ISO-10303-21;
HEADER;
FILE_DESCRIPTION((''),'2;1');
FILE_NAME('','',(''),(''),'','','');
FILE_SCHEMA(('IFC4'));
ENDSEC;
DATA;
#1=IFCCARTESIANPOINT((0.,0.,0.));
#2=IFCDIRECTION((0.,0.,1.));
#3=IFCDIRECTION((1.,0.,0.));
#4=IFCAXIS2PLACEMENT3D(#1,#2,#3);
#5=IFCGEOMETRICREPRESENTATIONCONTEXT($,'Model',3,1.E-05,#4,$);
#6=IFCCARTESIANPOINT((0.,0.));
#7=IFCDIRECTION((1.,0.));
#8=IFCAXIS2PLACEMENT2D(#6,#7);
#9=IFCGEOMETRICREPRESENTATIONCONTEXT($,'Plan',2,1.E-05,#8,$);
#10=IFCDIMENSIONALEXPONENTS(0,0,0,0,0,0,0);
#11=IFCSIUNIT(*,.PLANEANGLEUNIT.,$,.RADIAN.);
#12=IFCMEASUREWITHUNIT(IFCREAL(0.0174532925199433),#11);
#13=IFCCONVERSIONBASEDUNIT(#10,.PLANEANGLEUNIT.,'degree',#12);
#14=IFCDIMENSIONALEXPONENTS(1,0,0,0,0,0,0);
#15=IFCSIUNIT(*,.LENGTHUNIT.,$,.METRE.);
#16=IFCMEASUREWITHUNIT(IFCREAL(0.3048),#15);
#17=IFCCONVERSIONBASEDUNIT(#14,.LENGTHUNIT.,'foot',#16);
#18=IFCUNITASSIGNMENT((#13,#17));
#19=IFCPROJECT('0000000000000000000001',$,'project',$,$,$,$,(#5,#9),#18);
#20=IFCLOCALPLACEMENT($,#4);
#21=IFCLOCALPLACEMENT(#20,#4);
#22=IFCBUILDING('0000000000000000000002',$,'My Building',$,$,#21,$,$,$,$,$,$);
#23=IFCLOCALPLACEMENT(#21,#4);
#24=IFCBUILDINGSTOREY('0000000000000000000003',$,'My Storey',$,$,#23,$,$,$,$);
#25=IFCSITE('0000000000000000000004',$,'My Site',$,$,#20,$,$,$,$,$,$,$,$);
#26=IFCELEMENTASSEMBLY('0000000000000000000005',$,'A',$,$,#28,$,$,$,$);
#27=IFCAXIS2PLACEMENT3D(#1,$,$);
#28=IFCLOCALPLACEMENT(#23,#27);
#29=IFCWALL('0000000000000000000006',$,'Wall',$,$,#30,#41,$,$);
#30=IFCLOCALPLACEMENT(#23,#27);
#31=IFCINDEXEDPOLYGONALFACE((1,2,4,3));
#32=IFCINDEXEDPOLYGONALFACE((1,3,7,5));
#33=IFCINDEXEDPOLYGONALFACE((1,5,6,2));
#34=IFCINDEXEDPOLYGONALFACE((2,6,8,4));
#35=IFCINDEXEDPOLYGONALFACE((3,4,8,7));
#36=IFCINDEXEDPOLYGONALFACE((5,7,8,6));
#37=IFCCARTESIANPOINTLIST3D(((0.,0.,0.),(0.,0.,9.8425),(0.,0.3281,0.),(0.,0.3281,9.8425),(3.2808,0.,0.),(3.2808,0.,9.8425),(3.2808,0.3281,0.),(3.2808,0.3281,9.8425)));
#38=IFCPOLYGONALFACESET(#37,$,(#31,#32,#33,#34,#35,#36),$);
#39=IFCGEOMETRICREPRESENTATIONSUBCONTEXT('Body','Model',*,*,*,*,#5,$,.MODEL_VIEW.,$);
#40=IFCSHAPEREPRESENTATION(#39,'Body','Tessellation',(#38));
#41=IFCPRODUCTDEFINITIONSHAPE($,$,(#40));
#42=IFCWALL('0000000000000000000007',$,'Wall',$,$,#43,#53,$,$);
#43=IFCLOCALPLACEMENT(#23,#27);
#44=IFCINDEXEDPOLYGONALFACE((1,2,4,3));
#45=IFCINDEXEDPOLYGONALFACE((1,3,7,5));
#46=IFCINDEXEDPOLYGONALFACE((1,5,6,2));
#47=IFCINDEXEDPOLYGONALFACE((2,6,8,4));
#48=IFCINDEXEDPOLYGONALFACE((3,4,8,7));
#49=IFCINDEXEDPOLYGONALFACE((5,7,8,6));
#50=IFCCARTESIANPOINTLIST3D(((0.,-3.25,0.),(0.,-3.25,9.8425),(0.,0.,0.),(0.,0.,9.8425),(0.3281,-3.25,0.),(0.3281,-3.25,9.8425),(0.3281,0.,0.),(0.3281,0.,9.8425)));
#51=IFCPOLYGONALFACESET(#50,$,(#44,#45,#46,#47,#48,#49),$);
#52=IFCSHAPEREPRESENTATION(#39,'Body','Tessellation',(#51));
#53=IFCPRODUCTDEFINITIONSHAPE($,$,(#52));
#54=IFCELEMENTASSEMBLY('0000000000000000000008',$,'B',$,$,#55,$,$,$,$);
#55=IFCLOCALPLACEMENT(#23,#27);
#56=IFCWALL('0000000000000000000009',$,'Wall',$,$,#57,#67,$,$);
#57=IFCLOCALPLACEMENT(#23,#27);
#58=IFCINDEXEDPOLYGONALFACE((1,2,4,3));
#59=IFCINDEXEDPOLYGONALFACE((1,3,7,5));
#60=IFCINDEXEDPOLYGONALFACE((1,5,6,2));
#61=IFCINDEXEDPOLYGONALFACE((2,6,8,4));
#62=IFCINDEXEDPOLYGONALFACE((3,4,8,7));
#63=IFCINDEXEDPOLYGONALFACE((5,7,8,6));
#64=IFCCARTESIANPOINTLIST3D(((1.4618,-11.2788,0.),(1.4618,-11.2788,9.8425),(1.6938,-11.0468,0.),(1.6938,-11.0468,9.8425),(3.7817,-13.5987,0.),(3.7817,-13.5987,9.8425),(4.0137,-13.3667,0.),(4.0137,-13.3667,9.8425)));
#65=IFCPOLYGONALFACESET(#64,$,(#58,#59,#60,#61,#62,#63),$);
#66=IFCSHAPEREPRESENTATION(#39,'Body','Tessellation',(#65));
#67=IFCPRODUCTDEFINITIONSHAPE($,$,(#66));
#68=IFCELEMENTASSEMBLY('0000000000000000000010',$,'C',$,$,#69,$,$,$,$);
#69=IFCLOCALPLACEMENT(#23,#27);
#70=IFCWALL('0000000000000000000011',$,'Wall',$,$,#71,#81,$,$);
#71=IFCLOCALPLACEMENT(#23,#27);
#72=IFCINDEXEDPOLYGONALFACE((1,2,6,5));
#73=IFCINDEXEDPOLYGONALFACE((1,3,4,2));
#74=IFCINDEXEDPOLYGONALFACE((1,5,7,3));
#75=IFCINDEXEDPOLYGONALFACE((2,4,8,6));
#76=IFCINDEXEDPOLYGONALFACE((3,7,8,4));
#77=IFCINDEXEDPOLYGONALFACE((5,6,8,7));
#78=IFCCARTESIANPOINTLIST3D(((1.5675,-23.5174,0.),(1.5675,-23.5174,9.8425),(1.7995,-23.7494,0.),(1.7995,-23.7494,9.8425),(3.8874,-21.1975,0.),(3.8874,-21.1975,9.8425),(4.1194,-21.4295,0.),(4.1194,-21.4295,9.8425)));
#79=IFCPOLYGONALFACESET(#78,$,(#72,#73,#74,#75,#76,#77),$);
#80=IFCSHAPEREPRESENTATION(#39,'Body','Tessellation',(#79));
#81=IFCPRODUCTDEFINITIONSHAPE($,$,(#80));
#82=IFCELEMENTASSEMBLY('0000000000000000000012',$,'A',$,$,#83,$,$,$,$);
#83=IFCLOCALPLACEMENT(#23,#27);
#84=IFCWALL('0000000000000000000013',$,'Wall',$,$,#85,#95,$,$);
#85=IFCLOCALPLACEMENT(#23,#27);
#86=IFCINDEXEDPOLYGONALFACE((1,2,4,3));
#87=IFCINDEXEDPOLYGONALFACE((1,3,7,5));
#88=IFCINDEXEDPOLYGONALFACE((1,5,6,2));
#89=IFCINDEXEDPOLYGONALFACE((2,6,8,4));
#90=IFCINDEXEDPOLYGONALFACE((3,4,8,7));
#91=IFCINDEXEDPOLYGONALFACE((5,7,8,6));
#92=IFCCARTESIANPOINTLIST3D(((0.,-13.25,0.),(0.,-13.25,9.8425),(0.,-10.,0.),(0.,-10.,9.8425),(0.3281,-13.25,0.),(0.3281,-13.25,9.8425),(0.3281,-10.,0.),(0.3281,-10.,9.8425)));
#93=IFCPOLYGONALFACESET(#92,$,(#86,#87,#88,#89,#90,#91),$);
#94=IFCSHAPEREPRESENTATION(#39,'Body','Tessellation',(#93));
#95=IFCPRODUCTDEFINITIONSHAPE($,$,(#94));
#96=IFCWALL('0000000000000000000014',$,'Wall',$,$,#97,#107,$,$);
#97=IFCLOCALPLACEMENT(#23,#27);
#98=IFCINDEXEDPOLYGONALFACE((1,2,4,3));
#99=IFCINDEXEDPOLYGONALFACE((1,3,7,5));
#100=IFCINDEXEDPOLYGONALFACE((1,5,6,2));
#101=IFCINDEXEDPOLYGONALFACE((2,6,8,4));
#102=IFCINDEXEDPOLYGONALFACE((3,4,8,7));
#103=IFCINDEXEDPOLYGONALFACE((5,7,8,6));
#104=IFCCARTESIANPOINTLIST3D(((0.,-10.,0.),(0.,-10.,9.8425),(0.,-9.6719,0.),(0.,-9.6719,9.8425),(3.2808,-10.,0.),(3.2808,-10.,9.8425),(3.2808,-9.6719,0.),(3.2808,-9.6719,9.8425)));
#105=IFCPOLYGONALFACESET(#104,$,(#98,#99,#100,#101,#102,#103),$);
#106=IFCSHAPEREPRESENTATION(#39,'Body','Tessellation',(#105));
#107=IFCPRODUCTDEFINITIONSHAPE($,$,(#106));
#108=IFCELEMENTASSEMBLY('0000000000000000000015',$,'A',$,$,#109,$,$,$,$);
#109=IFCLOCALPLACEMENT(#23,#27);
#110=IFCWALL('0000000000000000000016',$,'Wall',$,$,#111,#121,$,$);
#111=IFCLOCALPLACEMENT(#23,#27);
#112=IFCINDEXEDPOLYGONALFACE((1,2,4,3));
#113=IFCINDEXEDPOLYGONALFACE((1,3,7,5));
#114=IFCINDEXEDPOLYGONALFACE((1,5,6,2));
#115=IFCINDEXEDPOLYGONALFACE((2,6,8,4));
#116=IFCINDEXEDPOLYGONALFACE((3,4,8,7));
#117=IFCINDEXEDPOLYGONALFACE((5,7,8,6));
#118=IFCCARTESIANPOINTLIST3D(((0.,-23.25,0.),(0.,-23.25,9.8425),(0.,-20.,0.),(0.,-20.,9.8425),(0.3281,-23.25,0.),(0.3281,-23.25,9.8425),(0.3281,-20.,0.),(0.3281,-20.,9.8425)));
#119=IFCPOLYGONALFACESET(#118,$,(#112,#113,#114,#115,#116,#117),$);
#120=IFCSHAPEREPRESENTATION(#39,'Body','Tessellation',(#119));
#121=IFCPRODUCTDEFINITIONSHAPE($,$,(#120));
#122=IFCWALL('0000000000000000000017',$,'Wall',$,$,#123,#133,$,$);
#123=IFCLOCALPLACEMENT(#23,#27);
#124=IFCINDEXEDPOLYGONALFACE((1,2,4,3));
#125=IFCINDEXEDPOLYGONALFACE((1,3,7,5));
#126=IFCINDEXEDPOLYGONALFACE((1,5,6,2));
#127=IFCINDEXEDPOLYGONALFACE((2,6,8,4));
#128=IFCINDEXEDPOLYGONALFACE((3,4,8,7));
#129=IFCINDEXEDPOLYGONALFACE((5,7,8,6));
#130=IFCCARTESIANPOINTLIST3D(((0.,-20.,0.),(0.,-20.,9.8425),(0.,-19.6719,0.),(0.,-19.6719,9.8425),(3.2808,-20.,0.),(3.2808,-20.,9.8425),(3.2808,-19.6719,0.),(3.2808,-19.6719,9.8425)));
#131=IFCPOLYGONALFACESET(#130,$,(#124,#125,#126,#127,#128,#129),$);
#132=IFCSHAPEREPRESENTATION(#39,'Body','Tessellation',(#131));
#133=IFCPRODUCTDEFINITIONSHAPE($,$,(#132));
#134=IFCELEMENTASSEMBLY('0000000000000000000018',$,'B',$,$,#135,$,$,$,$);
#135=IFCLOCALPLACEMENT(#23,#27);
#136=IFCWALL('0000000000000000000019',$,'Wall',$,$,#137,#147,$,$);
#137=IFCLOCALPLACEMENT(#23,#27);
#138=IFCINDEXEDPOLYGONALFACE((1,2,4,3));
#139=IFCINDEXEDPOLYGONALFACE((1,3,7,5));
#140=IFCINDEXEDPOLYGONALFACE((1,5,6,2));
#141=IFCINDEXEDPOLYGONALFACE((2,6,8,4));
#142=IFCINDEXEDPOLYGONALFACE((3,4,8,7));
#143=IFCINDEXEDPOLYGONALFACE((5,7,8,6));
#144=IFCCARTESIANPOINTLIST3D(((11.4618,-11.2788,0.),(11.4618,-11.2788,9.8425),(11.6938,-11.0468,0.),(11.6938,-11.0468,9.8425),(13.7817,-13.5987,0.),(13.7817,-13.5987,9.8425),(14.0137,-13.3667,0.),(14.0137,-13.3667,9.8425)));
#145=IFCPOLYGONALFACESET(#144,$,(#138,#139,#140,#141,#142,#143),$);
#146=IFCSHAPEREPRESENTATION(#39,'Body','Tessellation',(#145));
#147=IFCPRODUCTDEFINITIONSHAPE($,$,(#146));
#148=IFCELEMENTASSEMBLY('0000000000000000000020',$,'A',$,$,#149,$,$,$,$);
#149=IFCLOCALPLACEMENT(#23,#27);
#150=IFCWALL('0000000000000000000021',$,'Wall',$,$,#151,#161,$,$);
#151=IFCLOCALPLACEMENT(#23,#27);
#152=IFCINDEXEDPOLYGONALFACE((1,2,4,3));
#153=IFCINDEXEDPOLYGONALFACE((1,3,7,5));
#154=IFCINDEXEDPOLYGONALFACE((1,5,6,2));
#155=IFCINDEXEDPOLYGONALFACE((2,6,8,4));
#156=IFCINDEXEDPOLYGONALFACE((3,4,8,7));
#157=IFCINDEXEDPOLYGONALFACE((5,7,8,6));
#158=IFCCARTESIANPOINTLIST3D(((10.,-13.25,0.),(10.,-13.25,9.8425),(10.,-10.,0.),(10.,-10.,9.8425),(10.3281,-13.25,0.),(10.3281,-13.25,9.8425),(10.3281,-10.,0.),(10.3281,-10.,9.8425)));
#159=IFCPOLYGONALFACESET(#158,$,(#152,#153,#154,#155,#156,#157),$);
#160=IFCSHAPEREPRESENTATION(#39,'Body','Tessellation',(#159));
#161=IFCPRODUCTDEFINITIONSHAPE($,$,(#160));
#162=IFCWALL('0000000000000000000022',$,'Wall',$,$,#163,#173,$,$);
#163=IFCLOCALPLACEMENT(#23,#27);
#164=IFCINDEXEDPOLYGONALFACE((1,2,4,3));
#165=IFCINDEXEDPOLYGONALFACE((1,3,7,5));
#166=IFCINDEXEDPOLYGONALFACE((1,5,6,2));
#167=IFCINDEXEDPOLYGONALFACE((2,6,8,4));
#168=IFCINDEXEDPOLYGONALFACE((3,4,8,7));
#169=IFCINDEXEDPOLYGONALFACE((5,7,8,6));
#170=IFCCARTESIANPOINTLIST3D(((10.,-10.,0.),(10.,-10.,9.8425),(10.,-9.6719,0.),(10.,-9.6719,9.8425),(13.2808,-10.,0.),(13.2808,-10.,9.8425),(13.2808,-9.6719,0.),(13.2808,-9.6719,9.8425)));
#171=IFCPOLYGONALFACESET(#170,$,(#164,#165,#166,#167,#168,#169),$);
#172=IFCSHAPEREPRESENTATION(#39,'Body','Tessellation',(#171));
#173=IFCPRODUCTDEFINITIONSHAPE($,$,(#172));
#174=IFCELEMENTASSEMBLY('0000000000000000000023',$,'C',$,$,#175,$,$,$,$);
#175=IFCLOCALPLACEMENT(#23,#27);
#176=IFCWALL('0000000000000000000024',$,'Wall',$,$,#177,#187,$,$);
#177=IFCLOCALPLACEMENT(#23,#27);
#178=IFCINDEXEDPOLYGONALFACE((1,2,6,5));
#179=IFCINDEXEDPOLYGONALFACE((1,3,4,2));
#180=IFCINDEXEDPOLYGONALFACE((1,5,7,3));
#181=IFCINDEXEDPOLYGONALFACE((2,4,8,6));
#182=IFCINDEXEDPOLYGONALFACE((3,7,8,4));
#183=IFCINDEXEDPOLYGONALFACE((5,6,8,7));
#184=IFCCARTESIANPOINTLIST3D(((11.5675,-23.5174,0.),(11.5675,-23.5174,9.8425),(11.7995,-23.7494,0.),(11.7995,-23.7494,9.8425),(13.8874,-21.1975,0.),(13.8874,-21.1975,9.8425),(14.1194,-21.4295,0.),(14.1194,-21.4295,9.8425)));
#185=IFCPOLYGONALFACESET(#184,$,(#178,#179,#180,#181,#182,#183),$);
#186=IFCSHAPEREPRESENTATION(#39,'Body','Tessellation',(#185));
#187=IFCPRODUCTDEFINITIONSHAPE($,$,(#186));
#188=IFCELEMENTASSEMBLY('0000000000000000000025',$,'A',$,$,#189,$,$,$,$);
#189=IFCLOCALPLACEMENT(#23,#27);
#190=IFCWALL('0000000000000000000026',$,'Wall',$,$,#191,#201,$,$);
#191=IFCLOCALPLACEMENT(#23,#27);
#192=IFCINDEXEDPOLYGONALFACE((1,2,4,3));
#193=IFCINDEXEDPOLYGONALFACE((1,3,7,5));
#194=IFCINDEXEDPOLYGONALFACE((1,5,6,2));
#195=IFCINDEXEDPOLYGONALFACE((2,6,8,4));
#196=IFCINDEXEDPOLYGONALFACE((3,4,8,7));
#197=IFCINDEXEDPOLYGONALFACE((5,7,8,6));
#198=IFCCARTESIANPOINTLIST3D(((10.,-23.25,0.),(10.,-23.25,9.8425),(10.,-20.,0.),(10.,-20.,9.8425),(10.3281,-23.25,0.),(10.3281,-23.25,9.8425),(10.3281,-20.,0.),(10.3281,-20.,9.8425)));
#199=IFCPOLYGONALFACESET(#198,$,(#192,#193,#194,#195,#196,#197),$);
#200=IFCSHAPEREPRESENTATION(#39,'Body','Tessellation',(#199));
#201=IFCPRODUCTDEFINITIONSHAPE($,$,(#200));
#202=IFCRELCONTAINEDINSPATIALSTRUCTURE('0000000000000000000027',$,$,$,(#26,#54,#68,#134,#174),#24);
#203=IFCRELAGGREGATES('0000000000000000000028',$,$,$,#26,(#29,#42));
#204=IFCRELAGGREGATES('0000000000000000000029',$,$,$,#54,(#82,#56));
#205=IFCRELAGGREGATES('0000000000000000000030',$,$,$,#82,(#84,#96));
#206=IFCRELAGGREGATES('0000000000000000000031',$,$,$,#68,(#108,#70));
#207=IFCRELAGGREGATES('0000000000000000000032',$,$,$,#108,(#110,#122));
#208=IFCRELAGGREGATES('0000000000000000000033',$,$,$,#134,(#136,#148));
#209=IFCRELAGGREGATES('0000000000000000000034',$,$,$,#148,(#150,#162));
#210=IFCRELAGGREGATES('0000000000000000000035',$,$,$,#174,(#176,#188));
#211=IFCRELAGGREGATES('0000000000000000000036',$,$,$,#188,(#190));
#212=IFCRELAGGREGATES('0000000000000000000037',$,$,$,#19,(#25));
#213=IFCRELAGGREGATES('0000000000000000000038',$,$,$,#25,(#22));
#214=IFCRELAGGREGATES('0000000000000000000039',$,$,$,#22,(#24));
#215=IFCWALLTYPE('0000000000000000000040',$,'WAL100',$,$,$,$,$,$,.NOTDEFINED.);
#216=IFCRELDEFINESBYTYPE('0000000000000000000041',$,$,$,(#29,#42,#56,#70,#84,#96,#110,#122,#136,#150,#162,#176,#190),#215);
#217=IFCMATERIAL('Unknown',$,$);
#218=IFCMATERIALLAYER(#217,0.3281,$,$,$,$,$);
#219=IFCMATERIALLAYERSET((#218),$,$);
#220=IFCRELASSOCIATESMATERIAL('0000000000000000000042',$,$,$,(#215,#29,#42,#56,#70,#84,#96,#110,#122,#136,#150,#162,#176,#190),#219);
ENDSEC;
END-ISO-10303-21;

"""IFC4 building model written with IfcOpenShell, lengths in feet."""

from ifc_helpers import new_model, entity, si_unit, converted_unit, frame, origin_with_axes, origin_2d_with_axis, place, context, subcontext, project, spatial, indexed_curve, outline, extrude, material, layer, layer_set, layer_usage, type_object, element, aggregate, save


model = new_model("IFC4")

# Units and contexts
model_context = context("Model", 3, precision=1e-05, world=origin_with_axes())
plan_context = context("Plan", 2, precision=1e-05, world=origin_2d_with_axis())
body_context = subcontext(model_context, "Body", "Model", "MODEL_VIEW")
ifc_project = project(units=[converted_unit("PLANEANGLEUNIT", "degree", entity("IfcReal", 0.0174532925199433), si_unit("PLANEANGLEUNIT", "RADIAN"), dimensions=[0, 0, 0, 0, 0, 0, 0]), converted_unit("LENGTHUNIT", "foot", entity("IfcReal", 0.3048), si_unit("LENGTHUNIT", "METRE"), dimensions=[1, 0, 0, 0, 0, 0, 0])], contexts=[model_context, plan_context])

# Site, building, storey
site_placement = place(None, origin_with_axes())
site = spatial("IfcSite", under=ifc_project, at=site_placement, Name="My Site")
building_placement = place(site_placement, origin_with_axes())
building = spatial("IfcBuilding", under=site, at=building_placement, Name="My Building")
storey_placement = place(building_placement, origin_with_axes())
storey = spatial("IfcBuildingStorey", under=building, at=storey_placement, Name="My Storey")

# Element assembly, walls
assembly_1_placement = place(storey_placement, origin_with_axes())
assembly_1 = element("IfcElementAssembly", 1, at=assembly_1_placement, inside=storey, Name="A")
ifc_material = material(Name="Unknown")
ifc_layer = layer(ifc_material, 0.3281)
ifc_layer_set = layer_set([ifc_layer])
ifc_layer_usage_1 = layer_usage(ifc_layer_set, "AXIS2", "POSITIVE", 0.0)
wall_type = type_object("IfcWallType", Name="WAL100", PredefinedType="NOTDEFINED", material=ifc_layer_set)
wall_1_placement = place(assembly_1_placement, origin_with_axes())
wall_1 = element("IfcWall", 2, at=wall_1_placement, type_object=wall_type, material=ifc_layer_usage_1, Name="Wall", context=body_context, shape_type="SweptSolid", body=[
    extrude(outline(indexed_curve([(0.0, 0.0), (0.0, 0.3281), (3.2808, 0.3281), (3.2808, 0.0), (0.0, 0.0)], self_intersect=False)), origin_with_axes(), (0.0, 0.0, 1.0), 9.8425),
])
ifc_layer_usage_2 = layer_usage(ifc_layer_set, "AXIS2", "POSITIVE", 0.0)
wall_2_placement = place(assembly_1_placement, frame((0.0, 0.0, 0.0), z_axis=(0.0, 0.0, 1.0), x_axis=(0.0, -1.0, 0.0)))
wall_2 = element("IfcWall", 3, at=wall_2_placement, type_object=wall_type, material=ifc_layer_usage_2, Name="Wall", context=body_context, shape_type="SweptSolid", body=[
    extrude(outline(indexed_curve([(0.0, 0.0), (0.0, 0.3281), (3.25, 0.3281), (3.25, 0.0), (0.0, 0.0)], self_intersect=False)), origin_with_axes(), (0.0, 0.0, 1.0), 9.8425),
])
aggregate(assembly_1, [wall_1, wall_2])

# Element assemblies, walls
assembly_2_placement = place(storey_placement, origin_with_axes())
assembly_2 = element("IfcElementAssembly", 4, at=assembly_2_placement, inside=storey, Name="B")
ifc_layer_usage_3 = layer_usage(ifc_layer_set, "AXIS2", "POSITIVE", 0.0)
wall_3_placement = place(assembly_2_placement, frame((1.4618, -11.2788, 0.0), z_axis=(0.0, 0.0, 1.0), x_axis=(0.707107, -0.707107, 0.0)))
wall_3 = element("IfcWall", 5, at=wall_3_placement, type_object=wall_type, material=ifc_layer_usage_3, Name="Wall", context=body_context, shape_type="SweptSolid", body=[
    extrude(outline(indexed_curve([(0.0, 0.0), (0.0, 0.3281), (3.2808, 0.3281), (3.2808, 0.0), (0.0, 0.0)], self_intersect=False)), origin_with_axes(), (0.0, 0.0, 1.0), 9.8425),
])
assembly_3_placement = place(storey_placement, origin_with_axes())
assembly_3 = element("IfcElementAssembly", 6, at=assembly_3_placement, inside=storey, Name="C")
ifc_layer_usage_4 = layer_usage(ifc_layer_set, "AXIS2", "POSITIVE", 0.0)
wall_4_placement = place(assembly_3_placement, frame((1.7995, -23.7494, 0.0), z_axis=(0.0, 0.0, 1.0), x_axis=(0.707107, 0.707107, 0.0)))
wall_4 = element("IfcWall", 7, at=wall_4_placement, type_object=wall_type, material=ifc_layer_usage_4, Name="Wall", context=body_context, shape_type="SweptSolid", body=[
    extrude(outline(indexed_curve([(0.0, 0.0), (0.0, 0.3281), (3.2808, 0.3281), (3.2808, 0.0), (0.0, 0.0)], self_intersect=False)), origin_with_axes(), (0.0, 0.0, 1.0), 9.8425),
])

# Element assembly
assembly_4_placement = place(assembly_2_placement, frame((0.0, -10.0, 0.0), z_axis=(0.0, 0.0, 1.0), x_axis=(1.0, 0.0, 0.0)))
assembly_4 = element("IfcElementAssembly", 8, at=assembly_4_placement, Name="A")
aggregate(assembly_2, [assembly_4, wall_3])

# Walls
ifc_layer_usage_5 = layer_usage(ifc_layer_set, "AXIS2", "POSITIVE", 0.0)
wall_5_placement = place(assembly_4_placement, frame((0.0, 0.0, 0.0), z_axis=(0.0, 0.0, 1.0), x_axis=(0.0, -1.0, 0.0)))
wall_5 = element("IfcWall", 9, at=wall_5_placement, type_object=wall_type, material=ifc_layer_usage_5, Name="Wall", context=body_context, shape_type="SweptSolid", body=[
    extrude(outline(indexed_curve([(0.0, 0.0), (0.0, 0.3281), (3.25, 0.3281), (3.25, 0.0), (0.0, 0.0)], self_intersect=False)), origin_with_axes(), (0.0, 0.0, 1.0), 9.8425),
])
ifc_layer_usage_6 = layer_usage(ifc_layer_set, "AXIS2", "POSITIVE", 0.0)
wall_6_placement = place(assembly_4_placement, frame((0.0, 0.0, 0.0), z_axis=(0.0, 0.0, 1.0), x_axis=(1.0, 0.0, 0.0)))
wall_6 = element("IfcWall", 10, at=wall_6_placement, type_object=wall_type, material=ifc_layer_usage_6, Name="Wall", context=body_context, shape_type="SweptSolid", body=[
    extrude(outline(indexed_curve([(0.0, 0.0), (0.0, 0.3281), (3.2808, 0.3281), (3.2808, 0.0), (0.0, 0.0)], self_intersect=False)), origin_with_axes(), (0.0, 0.0, 1.0), 9.8425),
])
aggregate(assembly_4, [wall_5, wall_6])

# Element assembly
assembly_5_placement = place(assembly_3_placement, frame((0.0, -20.0, 0.0), z_axis=(0.0, 0.0, 1.0), x_axis=(1.0, 0.0, 0.0)))
assembly_5 = element("IfcElementAssembly", 11, at=assembly_5_placement, Name="A")
aggregate(assembly_3, [assembly_5, wall_4])

# Walls
ifc_layer_usage_7 = layer_usage(ifc_layer_set, "AXIS2", "POSITIVE", 0.0)
wall_7_placement = place(assembly_5_placement, frame((0.0, 0.0, 0.0), z_axis=(0.0, 0.0, 1.0), x_axis=(0.0, -1.0, 0.0)))
wall_7 = element("IfcWall", 12, at=wall_7_placement, type_object=wall_type, material=ifc_layer_usage_7, Name="Wall", context=body_context, shape_type="SweptSolid", body=[
    extrude(outline(indexed_curve([(0.0, 0.0), (0.0, 0.3281), (3.25, 0.3281), (3.25, 0.0), (0.0, 0.0)], self_intersect=False)), origin_with_axes(), (0.0, 0.0, 1.0), 9.8425),
])
ifc_layer_usage_8 = layer_usage(ifc_layer_set, "AXIS2", "POSITIVE", 0.0)
wall_8_placement = place(assembly_5_placement, frame((0.0, 0.0, 0.0), z_axis=(0.0, 0.0, 1.0), x_axis=(1.0, 0.0, 0.0)))
wall_8 = element("IfcWall", 13, at=wall_8_placement, type_object=wall_type, material=ifc_layer_usage_8, Name="Wall", context=body_context, shape_type="SweptSolid", body=[
    extrude(outline(indexed_curve([(0.0, 0.0), (0.0, 0.3281), (3.2808, 0.3281), (3.2808, 0.0), (0.0, 0.0)], self_intersect=False)), origin_with_axes(), (0.0, 0.0, 1.0), 9.8425),
])
aggregate(assembly_5, [wall_7, wall_8])

# Element assemblies, walls
assembly_6_placement = place(storey_placement, frame((10.0, 0.0, 0.0), z_axis=(0.0, 0.0, 1.0), x_axis=(1.0, 0.0, 0.0)))
assembly_6 = element("IfcElementAssembly", 14, at=assembly_6_placement, inside=storey, Name="B")
ifc_layer_usage_9 = layer_usage(ifc_layer_set, "AXIS2", "POSITIVE", 0.0)
wall_9_placement = place(assembly_6_placement, frame((1.4618, -11.2788, 0.0), z_axis=(0.0, 0.0, 1.0), x_axis=(0.707107, -0.707107, 0.0)))
wall_9 = element("IfcWall", 15, at=wall_9_placement, type_object=wall_type, material=ifc_layer_usage_9, Name="Wall", context=body_context, shape_type="SweptSolid", body=[
    extrude(outline(indexed_curve([(0.0, 0.0), (0.0, 0.3281), (3.2808, 0.3281), (3.2808, 0.0), (0.0, 0.0)], self_intersect=False)), origin_with_axes(), (0.0, 0.0, 1.0), 9.8425),
])
assembly_7_placement = place(assembly_6_placement, frame((0.0, -10.0, 0.0), z_axis=(0.0, 0.0, 1.0), x_axis=(1.0, 0.0, 0.0)))
assembly_7 = element("IfcElementAssembly", 16, at=assembly_7_placement, Name="A")
aggregate(assembly_6, [wall_9, assembly_7])
ifc_layer_usage_10 = layer_usage(ifc_layer_set, "AXIS2", "POSITIVE", 0.0)
wall_10_placement = place(assembly_7_placement, frame((0.0, 0.0, 0.0), z_axis=(0.0, 0.0, 1.0), x_axis=(0.0, -1.0, 0.0)))
wall_10 = element("IfcWall", 17, at=wall_10_placement, type_object=wall_type, material=ifc_layer_usage_10, Name="Wall", context=body_context, shape_type="SweptSolid", body=[
    extrude(outline(indexed_curve([(0.0, 0.0), (0.0, 0.3281), (3.25, 0.3281), (3.25, 0.0), (0.0, 0.0)], self_intersect=False)), origin_with_axes(), (0.0, 0.0, 1.0), 9.8425),
])
ifc_layer_usage_11 = layer_usage(ifc_layer_set, "AXIS2", "POSITIVE", 0.0)
wall_11_placement = place(assembly_7_placement, origin_with_axes())
wall_11 = element("IfcWall", 18, at=wall_11_placement, type_object=wall_type, material=ifc_layer_usage_11, Name="Wall", context=body_context, shape_type="SweptSolid", body=[
    extrude(outline(indexed_curve([(0.0, 0.0), (0.0, 0.3281), (3.2808, 0.3281), (3.2808, 0.0), (0.0, 0.0)], self_intersect=False)), origin_with_axes(), (0.0, 0.0, 1.0), 9.8425),
])
aggregate(assembly_7, [wall_10, wall_11])
assembly_8_placement = place(storey_placement, frame((10.0, 0.0, 0.0), z_axis=(0.0, 0.0, 1.0), x_axis=(1.0, 0.0, 0.0)))
assembly_8 = element("IfcElementAssembly", 19, at=assembly_8_placement, inside=storey, Name="C")
ifc_layer_usage_12 = layer_usage(ifc_layer_set, "AXIS2", "POSITIVE", 0.0)
wall_12_placement = place(assembly_8_placement, frame((1.7995, -23.7494, 0.0), z_axis=(0.0, 0.0, 1.0), x_axis=(0.707107, 0.707107, 0.0)))
wall_12 = element("IfcWall", 20, at=wall_12_placement, type_object=wall_type, material=ifc_layer_usage_12, Name="Wall", context=body_context, shape_type="SweptSolid", body=[
    extrude(outline(indexed_curve([(0.0, 0.0), (0.0, 0.3281), (3.2808, 0.3281), (3.2808, 0.0), (0.0, 0.0)], self_intersect=False)), origin_with_axes(), (0.0, 0.0, 1.0), 9.8425),
])
assembly_9_placement = place(assembly_8_placement, frame((0.0, -20.0, 0.0), z_axis=(0.0, 0.0, 1.0), x_axis=(1.0, 0.0, 0.0)))
assembly_9 = element("IfcElementAssembly", 21, at=assembly_9_placement, Name="A")
aggregate(assembly_8, [wall_12, assembly_9])
ifc_layer_usage_13 = layer_usage(ifc_layer_set, "AXIS2", "POSITIVE", 0.0)
wall_13_placement = place(assembly_9_placement, frame((0.0, 0.0, 0.0), z_axis=(0.0, 0.0, 1.0), x_axis=(0.0, -1.0, 0.0)))
wall_13 = element("IfcWall", 22, at=wall_13_placement, type_object=wall_type, material=ifc_layer_usage_13, Name="Wall", context=body_context, shape_type="SweptSolid", body=[
    extrude(outline(indexed_curve([(0.0, 0.0), (0.0, 0.3281), (3.25, 0.3281), (3.25, 0.0), (0.0, 0.0)], self_intersect=False)), origin_with_axes(), (0.0, 0.0, 1.0), 9.8425),
])
aggregate(assembly_9, [wall_13])

save(model, "model.ifc")
